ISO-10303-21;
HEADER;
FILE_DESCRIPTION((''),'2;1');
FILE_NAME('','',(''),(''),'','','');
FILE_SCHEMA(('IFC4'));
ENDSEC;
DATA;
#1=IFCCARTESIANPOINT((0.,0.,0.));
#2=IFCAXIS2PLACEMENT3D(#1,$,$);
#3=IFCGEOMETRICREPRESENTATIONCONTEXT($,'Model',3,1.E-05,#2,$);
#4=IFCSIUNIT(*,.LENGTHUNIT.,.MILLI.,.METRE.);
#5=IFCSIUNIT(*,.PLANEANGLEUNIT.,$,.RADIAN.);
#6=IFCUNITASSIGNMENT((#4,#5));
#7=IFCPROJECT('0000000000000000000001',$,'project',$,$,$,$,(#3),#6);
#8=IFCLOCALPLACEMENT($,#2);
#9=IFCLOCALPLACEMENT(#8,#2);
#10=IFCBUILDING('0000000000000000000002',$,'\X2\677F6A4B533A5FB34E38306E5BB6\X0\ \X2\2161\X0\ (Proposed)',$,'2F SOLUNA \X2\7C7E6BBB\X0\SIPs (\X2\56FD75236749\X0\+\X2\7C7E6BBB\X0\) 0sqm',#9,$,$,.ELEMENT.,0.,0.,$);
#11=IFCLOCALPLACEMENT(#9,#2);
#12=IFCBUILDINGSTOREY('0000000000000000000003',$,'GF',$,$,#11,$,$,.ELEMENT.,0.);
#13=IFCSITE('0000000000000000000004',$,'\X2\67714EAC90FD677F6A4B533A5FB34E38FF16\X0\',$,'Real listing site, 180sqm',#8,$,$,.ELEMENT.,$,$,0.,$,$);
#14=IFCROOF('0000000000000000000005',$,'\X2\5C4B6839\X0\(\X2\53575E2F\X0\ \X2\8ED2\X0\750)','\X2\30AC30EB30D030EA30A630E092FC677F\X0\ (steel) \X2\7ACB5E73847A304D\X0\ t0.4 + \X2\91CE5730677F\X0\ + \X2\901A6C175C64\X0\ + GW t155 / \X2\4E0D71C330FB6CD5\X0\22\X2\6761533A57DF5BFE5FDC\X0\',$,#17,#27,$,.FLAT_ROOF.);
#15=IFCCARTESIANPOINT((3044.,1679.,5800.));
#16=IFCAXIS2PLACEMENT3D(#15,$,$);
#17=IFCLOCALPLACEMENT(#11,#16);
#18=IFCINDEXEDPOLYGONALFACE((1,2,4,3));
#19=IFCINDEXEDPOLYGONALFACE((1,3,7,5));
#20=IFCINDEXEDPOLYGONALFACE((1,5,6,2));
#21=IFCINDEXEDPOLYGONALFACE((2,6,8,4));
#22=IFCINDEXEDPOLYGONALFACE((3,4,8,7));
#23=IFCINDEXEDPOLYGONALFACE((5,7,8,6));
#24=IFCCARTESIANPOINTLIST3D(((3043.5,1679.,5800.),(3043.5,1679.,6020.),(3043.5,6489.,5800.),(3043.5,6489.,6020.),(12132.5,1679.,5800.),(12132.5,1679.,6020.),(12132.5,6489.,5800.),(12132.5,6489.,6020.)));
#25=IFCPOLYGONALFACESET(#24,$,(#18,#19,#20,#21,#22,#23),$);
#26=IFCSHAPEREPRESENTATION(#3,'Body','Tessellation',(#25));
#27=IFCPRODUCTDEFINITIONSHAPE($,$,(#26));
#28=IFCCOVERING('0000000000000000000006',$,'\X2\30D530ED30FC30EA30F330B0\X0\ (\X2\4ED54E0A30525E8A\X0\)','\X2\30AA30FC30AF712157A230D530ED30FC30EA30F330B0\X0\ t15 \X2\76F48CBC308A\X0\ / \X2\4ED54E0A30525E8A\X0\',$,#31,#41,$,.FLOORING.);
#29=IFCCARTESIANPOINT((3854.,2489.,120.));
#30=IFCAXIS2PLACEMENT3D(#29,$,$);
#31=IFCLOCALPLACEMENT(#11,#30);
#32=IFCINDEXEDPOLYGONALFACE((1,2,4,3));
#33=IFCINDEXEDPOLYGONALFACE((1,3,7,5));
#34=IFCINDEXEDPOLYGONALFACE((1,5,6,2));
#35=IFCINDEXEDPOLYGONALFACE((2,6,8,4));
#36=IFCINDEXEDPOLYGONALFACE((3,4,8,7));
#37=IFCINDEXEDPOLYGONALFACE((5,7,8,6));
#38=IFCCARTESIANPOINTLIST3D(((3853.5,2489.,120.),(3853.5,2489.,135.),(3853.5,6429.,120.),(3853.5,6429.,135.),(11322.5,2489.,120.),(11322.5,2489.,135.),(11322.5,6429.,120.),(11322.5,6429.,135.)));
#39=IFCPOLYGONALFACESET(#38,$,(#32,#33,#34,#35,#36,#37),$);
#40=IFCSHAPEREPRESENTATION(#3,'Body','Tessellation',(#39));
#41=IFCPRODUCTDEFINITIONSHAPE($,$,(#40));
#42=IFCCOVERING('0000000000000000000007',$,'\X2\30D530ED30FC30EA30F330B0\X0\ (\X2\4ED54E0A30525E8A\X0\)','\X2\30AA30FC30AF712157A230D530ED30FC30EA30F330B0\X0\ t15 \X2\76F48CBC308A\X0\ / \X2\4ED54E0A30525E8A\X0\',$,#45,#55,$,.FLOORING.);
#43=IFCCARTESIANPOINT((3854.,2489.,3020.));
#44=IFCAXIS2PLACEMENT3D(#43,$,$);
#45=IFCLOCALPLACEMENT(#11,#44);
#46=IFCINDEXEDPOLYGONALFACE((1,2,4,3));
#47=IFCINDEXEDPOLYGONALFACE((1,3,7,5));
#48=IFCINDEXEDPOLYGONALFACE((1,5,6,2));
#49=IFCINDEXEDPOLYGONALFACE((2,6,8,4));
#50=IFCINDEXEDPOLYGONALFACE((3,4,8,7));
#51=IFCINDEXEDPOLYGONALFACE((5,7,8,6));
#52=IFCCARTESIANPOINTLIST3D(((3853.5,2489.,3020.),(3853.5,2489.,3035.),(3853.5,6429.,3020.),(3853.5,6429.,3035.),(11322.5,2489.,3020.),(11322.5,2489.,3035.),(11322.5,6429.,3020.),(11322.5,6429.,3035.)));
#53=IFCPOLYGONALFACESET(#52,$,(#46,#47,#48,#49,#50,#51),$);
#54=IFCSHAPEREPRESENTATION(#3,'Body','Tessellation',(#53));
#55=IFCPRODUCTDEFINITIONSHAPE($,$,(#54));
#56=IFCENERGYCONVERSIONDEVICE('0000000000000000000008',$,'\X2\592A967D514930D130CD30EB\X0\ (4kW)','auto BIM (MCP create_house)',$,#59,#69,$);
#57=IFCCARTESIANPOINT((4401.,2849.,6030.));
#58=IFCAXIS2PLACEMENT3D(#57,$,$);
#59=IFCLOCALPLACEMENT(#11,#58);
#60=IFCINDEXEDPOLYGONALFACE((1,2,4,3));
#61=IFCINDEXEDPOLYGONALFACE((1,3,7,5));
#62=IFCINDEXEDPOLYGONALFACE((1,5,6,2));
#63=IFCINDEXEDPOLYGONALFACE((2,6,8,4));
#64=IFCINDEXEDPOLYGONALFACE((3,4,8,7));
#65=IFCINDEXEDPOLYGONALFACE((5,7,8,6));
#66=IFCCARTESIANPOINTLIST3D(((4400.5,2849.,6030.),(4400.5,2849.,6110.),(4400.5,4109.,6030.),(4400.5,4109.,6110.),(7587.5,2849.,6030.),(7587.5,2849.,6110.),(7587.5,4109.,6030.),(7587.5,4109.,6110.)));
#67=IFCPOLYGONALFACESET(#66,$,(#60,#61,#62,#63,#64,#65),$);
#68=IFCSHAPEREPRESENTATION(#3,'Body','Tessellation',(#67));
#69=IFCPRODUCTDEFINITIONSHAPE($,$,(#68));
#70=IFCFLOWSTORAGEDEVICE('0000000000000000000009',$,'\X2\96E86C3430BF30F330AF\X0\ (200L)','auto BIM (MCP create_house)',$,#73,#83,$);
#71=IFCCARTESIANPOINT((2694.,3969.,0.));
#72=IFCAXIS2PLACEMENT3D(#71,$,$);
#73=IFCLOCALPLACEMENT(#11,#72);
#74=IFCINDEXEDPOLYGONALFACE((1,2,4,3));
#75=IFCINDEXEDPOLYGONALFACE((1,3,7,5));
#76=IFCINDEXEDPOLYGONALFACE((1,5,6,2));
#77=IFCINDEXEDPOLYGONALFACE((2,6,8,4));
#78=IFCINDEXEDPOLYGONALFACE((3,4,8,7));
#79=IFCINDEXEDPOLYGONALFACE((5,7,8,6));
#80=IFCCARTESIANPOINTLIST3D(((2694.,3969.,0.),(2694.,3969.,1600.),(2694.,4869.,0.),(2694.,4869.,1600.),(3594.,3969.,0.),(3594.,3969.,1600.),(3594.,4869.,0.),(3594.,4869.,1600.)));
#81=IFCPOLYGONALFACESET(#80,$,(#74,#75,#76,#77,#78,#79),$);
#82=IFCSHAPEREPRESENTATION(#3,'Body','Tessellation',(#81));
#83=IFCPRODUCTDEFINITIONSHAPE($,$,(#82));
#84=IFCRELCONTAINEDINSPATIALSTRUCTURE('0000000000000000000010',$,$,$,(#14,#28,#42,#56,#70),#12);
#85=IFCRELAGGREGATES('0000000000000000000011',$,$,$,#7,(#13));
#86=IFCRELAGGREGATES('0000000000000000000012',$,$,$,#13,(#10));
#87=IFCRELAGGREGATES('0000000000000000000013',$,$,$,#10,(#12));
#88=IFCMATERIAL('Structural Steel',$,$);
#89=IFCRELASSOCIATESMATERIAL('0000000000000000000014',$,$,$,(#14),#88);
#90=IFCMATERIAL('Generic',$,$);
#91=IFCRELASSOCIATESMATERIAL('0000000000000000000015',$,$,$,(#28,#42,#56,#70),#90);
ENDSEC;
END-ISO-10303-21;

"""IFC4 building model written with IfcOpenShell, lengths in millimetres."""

from ifc_helpers import new_model, si_unit, frame, frame_2d, origin, place, context, project, spatial, rectangle, extrude, material, element, save


model = new_model("IFC4")

# Units and contexts
model_context = context("Model", 3, precision=1e-05, world=origin())
ifc_project = project(units=[si_unit("LENGTHUNIT", "METRE", prefix="MILLI"), si_unit("PLANEANGLEUNIT", "RADIAN")], contexts=[model_context])

# Site, building, storey
site_placement = place(None, origin())
site = spatial("IfcSite", under=ifc_project, at=site_placement, Name="東京都板橋区徳丸６", ObjectType="Real listing site, 180sqm", CompositionType="ELEMENT", RefElevation=0.0)
building_placement = place(site_placement, origin())
building = spatial("IfcBuilding", under=site, at=building_placement, Name="板橋区徳丸の家 Ⅱ (Proposed)", ObjectType="2F SOLUNA 籾殻SIPs (国産杉+籾殻) 0sqm", CompositionType="ELEMENT", ElevationOfRefHeight=0.0, ElevationOfTerrain=0.0)
storey_placement = place(building_placement, origin())
storey = spatial("IfcBuildingStorey", under=building, at=storey_placement, Name="GF", CompositionType="ELEMENT", Elevation=0.0)

# Roof
ifc_material_1 = material(Name="Structural Steel")
for number, where, name in (
    (1, (3044.0, 1679.0, 5800.0), "屋根(南帯 軒750)"),
):
    element("IfcRoof", number, at=place(storey_placement, frame(where)), inside=storey, material=ifc_material_1, Name=name, Description="ガルバリウム鋼板 (steel) 立平葺き t0.4 + 野地板 + 通気層 + GW t155 / 不燃・法22条区域対応", PredefinedType="FLAT_ROOF", context=model_context, shape_type="SweptSolid", body=[
        extrude(rectangle(XDim=9089.0, YDim=4810.0, at=frame_2d((4544.0, 2405.0))), frame((3044.0, 1679.0, 5800.0)), (0.0, 0.0, 1.0), 220.0),
    ])

# Coverings
ifc_material_2 = material(Name="Generic")
covering_1_placement = place(storey_placement, frame((3854.0, 2489.0, 120.0)))
element("IfcCovering", 2, at=covering_1_placement, inside=storey, material=ifc_material_2, Name="フローリング (仕上げ床)", Description="オーク無垢フローリング t15 直貼り / 仕上げ床", PredefinedType="FLOORING", context=model_context, shape_type="SweptSolid", body=[
    extrude(rectangle(XDim=7469.0, YDim=3940.0, at=frame_2d((3734.0, 1970.0))), frame((3854.0, 2489.0, 120.0)), (0.0, 0.0, 1.0), 15.0),
])
covering_2_placement = place(storey_placement, frame((3854.0, 2489.0, 3020.0)))
element("IfcCovering", 3, at=covering_2_placement, inside=storey, material=ifc_material_2, Name="フローリング (仕上げ床)", Description="オーク無垢フローリング t15 直貼り / 仕上げ床", PredefinedType="FLOORING", context=model_context, shape_type="SweptSolid", body=[
    extrude(rectangle(XDim=7469.0, YDim=3940.0, at=frame_2d((3734.0, 1970.0))), frame((3854.0, 2489.0, 3020.0)), (0.0, 0.0, 1.0), 15.0),
])

# Energy conversion device
energy_conversion_device_placement = place(storey_placement, frame((4401.0, 2849.0, 6030.0)))
element("IfcEnergyConversionDevice", 4, at=energy_conversion_device_placement, inside=storey, material=ifc_material_2, Name="太陽光パネル (4kW)", Description="auto BIM (MCP create_house)", context=model_context, shape_type="SweptSolid", body=[
    extrude(rectangle(XDim=3187.0, YDim=1260.0, at=frame_2d((1593.0, 630.0))), frame((4401.0, 2849.0, 6030.0)), (0.0, 0.0, 1.0), 80.0),
])

# Flow storage device
flow_storage_device_placement = place(storey_placement, frame((2694.0, 3969.0, 0.0)))
element("IfcFlowStorageDevice", 5, at=flow_storage_device_placement, inside=storey, material=ifc_material_2, Name="雨水タンク (200L)", Description="auto BIM (MCP create_house)", context=model_context, shape_type="SweptSolid", body=[
    extrude(rectangle(XDim=900.0, YDim=900.0, at=frame_2d((450.0, 450.0))), frame((2694.0, 3969.0, 0.0)), (0.0, 0.0, 1.0), 1600.0),
])

save(model, "model.ifc")
